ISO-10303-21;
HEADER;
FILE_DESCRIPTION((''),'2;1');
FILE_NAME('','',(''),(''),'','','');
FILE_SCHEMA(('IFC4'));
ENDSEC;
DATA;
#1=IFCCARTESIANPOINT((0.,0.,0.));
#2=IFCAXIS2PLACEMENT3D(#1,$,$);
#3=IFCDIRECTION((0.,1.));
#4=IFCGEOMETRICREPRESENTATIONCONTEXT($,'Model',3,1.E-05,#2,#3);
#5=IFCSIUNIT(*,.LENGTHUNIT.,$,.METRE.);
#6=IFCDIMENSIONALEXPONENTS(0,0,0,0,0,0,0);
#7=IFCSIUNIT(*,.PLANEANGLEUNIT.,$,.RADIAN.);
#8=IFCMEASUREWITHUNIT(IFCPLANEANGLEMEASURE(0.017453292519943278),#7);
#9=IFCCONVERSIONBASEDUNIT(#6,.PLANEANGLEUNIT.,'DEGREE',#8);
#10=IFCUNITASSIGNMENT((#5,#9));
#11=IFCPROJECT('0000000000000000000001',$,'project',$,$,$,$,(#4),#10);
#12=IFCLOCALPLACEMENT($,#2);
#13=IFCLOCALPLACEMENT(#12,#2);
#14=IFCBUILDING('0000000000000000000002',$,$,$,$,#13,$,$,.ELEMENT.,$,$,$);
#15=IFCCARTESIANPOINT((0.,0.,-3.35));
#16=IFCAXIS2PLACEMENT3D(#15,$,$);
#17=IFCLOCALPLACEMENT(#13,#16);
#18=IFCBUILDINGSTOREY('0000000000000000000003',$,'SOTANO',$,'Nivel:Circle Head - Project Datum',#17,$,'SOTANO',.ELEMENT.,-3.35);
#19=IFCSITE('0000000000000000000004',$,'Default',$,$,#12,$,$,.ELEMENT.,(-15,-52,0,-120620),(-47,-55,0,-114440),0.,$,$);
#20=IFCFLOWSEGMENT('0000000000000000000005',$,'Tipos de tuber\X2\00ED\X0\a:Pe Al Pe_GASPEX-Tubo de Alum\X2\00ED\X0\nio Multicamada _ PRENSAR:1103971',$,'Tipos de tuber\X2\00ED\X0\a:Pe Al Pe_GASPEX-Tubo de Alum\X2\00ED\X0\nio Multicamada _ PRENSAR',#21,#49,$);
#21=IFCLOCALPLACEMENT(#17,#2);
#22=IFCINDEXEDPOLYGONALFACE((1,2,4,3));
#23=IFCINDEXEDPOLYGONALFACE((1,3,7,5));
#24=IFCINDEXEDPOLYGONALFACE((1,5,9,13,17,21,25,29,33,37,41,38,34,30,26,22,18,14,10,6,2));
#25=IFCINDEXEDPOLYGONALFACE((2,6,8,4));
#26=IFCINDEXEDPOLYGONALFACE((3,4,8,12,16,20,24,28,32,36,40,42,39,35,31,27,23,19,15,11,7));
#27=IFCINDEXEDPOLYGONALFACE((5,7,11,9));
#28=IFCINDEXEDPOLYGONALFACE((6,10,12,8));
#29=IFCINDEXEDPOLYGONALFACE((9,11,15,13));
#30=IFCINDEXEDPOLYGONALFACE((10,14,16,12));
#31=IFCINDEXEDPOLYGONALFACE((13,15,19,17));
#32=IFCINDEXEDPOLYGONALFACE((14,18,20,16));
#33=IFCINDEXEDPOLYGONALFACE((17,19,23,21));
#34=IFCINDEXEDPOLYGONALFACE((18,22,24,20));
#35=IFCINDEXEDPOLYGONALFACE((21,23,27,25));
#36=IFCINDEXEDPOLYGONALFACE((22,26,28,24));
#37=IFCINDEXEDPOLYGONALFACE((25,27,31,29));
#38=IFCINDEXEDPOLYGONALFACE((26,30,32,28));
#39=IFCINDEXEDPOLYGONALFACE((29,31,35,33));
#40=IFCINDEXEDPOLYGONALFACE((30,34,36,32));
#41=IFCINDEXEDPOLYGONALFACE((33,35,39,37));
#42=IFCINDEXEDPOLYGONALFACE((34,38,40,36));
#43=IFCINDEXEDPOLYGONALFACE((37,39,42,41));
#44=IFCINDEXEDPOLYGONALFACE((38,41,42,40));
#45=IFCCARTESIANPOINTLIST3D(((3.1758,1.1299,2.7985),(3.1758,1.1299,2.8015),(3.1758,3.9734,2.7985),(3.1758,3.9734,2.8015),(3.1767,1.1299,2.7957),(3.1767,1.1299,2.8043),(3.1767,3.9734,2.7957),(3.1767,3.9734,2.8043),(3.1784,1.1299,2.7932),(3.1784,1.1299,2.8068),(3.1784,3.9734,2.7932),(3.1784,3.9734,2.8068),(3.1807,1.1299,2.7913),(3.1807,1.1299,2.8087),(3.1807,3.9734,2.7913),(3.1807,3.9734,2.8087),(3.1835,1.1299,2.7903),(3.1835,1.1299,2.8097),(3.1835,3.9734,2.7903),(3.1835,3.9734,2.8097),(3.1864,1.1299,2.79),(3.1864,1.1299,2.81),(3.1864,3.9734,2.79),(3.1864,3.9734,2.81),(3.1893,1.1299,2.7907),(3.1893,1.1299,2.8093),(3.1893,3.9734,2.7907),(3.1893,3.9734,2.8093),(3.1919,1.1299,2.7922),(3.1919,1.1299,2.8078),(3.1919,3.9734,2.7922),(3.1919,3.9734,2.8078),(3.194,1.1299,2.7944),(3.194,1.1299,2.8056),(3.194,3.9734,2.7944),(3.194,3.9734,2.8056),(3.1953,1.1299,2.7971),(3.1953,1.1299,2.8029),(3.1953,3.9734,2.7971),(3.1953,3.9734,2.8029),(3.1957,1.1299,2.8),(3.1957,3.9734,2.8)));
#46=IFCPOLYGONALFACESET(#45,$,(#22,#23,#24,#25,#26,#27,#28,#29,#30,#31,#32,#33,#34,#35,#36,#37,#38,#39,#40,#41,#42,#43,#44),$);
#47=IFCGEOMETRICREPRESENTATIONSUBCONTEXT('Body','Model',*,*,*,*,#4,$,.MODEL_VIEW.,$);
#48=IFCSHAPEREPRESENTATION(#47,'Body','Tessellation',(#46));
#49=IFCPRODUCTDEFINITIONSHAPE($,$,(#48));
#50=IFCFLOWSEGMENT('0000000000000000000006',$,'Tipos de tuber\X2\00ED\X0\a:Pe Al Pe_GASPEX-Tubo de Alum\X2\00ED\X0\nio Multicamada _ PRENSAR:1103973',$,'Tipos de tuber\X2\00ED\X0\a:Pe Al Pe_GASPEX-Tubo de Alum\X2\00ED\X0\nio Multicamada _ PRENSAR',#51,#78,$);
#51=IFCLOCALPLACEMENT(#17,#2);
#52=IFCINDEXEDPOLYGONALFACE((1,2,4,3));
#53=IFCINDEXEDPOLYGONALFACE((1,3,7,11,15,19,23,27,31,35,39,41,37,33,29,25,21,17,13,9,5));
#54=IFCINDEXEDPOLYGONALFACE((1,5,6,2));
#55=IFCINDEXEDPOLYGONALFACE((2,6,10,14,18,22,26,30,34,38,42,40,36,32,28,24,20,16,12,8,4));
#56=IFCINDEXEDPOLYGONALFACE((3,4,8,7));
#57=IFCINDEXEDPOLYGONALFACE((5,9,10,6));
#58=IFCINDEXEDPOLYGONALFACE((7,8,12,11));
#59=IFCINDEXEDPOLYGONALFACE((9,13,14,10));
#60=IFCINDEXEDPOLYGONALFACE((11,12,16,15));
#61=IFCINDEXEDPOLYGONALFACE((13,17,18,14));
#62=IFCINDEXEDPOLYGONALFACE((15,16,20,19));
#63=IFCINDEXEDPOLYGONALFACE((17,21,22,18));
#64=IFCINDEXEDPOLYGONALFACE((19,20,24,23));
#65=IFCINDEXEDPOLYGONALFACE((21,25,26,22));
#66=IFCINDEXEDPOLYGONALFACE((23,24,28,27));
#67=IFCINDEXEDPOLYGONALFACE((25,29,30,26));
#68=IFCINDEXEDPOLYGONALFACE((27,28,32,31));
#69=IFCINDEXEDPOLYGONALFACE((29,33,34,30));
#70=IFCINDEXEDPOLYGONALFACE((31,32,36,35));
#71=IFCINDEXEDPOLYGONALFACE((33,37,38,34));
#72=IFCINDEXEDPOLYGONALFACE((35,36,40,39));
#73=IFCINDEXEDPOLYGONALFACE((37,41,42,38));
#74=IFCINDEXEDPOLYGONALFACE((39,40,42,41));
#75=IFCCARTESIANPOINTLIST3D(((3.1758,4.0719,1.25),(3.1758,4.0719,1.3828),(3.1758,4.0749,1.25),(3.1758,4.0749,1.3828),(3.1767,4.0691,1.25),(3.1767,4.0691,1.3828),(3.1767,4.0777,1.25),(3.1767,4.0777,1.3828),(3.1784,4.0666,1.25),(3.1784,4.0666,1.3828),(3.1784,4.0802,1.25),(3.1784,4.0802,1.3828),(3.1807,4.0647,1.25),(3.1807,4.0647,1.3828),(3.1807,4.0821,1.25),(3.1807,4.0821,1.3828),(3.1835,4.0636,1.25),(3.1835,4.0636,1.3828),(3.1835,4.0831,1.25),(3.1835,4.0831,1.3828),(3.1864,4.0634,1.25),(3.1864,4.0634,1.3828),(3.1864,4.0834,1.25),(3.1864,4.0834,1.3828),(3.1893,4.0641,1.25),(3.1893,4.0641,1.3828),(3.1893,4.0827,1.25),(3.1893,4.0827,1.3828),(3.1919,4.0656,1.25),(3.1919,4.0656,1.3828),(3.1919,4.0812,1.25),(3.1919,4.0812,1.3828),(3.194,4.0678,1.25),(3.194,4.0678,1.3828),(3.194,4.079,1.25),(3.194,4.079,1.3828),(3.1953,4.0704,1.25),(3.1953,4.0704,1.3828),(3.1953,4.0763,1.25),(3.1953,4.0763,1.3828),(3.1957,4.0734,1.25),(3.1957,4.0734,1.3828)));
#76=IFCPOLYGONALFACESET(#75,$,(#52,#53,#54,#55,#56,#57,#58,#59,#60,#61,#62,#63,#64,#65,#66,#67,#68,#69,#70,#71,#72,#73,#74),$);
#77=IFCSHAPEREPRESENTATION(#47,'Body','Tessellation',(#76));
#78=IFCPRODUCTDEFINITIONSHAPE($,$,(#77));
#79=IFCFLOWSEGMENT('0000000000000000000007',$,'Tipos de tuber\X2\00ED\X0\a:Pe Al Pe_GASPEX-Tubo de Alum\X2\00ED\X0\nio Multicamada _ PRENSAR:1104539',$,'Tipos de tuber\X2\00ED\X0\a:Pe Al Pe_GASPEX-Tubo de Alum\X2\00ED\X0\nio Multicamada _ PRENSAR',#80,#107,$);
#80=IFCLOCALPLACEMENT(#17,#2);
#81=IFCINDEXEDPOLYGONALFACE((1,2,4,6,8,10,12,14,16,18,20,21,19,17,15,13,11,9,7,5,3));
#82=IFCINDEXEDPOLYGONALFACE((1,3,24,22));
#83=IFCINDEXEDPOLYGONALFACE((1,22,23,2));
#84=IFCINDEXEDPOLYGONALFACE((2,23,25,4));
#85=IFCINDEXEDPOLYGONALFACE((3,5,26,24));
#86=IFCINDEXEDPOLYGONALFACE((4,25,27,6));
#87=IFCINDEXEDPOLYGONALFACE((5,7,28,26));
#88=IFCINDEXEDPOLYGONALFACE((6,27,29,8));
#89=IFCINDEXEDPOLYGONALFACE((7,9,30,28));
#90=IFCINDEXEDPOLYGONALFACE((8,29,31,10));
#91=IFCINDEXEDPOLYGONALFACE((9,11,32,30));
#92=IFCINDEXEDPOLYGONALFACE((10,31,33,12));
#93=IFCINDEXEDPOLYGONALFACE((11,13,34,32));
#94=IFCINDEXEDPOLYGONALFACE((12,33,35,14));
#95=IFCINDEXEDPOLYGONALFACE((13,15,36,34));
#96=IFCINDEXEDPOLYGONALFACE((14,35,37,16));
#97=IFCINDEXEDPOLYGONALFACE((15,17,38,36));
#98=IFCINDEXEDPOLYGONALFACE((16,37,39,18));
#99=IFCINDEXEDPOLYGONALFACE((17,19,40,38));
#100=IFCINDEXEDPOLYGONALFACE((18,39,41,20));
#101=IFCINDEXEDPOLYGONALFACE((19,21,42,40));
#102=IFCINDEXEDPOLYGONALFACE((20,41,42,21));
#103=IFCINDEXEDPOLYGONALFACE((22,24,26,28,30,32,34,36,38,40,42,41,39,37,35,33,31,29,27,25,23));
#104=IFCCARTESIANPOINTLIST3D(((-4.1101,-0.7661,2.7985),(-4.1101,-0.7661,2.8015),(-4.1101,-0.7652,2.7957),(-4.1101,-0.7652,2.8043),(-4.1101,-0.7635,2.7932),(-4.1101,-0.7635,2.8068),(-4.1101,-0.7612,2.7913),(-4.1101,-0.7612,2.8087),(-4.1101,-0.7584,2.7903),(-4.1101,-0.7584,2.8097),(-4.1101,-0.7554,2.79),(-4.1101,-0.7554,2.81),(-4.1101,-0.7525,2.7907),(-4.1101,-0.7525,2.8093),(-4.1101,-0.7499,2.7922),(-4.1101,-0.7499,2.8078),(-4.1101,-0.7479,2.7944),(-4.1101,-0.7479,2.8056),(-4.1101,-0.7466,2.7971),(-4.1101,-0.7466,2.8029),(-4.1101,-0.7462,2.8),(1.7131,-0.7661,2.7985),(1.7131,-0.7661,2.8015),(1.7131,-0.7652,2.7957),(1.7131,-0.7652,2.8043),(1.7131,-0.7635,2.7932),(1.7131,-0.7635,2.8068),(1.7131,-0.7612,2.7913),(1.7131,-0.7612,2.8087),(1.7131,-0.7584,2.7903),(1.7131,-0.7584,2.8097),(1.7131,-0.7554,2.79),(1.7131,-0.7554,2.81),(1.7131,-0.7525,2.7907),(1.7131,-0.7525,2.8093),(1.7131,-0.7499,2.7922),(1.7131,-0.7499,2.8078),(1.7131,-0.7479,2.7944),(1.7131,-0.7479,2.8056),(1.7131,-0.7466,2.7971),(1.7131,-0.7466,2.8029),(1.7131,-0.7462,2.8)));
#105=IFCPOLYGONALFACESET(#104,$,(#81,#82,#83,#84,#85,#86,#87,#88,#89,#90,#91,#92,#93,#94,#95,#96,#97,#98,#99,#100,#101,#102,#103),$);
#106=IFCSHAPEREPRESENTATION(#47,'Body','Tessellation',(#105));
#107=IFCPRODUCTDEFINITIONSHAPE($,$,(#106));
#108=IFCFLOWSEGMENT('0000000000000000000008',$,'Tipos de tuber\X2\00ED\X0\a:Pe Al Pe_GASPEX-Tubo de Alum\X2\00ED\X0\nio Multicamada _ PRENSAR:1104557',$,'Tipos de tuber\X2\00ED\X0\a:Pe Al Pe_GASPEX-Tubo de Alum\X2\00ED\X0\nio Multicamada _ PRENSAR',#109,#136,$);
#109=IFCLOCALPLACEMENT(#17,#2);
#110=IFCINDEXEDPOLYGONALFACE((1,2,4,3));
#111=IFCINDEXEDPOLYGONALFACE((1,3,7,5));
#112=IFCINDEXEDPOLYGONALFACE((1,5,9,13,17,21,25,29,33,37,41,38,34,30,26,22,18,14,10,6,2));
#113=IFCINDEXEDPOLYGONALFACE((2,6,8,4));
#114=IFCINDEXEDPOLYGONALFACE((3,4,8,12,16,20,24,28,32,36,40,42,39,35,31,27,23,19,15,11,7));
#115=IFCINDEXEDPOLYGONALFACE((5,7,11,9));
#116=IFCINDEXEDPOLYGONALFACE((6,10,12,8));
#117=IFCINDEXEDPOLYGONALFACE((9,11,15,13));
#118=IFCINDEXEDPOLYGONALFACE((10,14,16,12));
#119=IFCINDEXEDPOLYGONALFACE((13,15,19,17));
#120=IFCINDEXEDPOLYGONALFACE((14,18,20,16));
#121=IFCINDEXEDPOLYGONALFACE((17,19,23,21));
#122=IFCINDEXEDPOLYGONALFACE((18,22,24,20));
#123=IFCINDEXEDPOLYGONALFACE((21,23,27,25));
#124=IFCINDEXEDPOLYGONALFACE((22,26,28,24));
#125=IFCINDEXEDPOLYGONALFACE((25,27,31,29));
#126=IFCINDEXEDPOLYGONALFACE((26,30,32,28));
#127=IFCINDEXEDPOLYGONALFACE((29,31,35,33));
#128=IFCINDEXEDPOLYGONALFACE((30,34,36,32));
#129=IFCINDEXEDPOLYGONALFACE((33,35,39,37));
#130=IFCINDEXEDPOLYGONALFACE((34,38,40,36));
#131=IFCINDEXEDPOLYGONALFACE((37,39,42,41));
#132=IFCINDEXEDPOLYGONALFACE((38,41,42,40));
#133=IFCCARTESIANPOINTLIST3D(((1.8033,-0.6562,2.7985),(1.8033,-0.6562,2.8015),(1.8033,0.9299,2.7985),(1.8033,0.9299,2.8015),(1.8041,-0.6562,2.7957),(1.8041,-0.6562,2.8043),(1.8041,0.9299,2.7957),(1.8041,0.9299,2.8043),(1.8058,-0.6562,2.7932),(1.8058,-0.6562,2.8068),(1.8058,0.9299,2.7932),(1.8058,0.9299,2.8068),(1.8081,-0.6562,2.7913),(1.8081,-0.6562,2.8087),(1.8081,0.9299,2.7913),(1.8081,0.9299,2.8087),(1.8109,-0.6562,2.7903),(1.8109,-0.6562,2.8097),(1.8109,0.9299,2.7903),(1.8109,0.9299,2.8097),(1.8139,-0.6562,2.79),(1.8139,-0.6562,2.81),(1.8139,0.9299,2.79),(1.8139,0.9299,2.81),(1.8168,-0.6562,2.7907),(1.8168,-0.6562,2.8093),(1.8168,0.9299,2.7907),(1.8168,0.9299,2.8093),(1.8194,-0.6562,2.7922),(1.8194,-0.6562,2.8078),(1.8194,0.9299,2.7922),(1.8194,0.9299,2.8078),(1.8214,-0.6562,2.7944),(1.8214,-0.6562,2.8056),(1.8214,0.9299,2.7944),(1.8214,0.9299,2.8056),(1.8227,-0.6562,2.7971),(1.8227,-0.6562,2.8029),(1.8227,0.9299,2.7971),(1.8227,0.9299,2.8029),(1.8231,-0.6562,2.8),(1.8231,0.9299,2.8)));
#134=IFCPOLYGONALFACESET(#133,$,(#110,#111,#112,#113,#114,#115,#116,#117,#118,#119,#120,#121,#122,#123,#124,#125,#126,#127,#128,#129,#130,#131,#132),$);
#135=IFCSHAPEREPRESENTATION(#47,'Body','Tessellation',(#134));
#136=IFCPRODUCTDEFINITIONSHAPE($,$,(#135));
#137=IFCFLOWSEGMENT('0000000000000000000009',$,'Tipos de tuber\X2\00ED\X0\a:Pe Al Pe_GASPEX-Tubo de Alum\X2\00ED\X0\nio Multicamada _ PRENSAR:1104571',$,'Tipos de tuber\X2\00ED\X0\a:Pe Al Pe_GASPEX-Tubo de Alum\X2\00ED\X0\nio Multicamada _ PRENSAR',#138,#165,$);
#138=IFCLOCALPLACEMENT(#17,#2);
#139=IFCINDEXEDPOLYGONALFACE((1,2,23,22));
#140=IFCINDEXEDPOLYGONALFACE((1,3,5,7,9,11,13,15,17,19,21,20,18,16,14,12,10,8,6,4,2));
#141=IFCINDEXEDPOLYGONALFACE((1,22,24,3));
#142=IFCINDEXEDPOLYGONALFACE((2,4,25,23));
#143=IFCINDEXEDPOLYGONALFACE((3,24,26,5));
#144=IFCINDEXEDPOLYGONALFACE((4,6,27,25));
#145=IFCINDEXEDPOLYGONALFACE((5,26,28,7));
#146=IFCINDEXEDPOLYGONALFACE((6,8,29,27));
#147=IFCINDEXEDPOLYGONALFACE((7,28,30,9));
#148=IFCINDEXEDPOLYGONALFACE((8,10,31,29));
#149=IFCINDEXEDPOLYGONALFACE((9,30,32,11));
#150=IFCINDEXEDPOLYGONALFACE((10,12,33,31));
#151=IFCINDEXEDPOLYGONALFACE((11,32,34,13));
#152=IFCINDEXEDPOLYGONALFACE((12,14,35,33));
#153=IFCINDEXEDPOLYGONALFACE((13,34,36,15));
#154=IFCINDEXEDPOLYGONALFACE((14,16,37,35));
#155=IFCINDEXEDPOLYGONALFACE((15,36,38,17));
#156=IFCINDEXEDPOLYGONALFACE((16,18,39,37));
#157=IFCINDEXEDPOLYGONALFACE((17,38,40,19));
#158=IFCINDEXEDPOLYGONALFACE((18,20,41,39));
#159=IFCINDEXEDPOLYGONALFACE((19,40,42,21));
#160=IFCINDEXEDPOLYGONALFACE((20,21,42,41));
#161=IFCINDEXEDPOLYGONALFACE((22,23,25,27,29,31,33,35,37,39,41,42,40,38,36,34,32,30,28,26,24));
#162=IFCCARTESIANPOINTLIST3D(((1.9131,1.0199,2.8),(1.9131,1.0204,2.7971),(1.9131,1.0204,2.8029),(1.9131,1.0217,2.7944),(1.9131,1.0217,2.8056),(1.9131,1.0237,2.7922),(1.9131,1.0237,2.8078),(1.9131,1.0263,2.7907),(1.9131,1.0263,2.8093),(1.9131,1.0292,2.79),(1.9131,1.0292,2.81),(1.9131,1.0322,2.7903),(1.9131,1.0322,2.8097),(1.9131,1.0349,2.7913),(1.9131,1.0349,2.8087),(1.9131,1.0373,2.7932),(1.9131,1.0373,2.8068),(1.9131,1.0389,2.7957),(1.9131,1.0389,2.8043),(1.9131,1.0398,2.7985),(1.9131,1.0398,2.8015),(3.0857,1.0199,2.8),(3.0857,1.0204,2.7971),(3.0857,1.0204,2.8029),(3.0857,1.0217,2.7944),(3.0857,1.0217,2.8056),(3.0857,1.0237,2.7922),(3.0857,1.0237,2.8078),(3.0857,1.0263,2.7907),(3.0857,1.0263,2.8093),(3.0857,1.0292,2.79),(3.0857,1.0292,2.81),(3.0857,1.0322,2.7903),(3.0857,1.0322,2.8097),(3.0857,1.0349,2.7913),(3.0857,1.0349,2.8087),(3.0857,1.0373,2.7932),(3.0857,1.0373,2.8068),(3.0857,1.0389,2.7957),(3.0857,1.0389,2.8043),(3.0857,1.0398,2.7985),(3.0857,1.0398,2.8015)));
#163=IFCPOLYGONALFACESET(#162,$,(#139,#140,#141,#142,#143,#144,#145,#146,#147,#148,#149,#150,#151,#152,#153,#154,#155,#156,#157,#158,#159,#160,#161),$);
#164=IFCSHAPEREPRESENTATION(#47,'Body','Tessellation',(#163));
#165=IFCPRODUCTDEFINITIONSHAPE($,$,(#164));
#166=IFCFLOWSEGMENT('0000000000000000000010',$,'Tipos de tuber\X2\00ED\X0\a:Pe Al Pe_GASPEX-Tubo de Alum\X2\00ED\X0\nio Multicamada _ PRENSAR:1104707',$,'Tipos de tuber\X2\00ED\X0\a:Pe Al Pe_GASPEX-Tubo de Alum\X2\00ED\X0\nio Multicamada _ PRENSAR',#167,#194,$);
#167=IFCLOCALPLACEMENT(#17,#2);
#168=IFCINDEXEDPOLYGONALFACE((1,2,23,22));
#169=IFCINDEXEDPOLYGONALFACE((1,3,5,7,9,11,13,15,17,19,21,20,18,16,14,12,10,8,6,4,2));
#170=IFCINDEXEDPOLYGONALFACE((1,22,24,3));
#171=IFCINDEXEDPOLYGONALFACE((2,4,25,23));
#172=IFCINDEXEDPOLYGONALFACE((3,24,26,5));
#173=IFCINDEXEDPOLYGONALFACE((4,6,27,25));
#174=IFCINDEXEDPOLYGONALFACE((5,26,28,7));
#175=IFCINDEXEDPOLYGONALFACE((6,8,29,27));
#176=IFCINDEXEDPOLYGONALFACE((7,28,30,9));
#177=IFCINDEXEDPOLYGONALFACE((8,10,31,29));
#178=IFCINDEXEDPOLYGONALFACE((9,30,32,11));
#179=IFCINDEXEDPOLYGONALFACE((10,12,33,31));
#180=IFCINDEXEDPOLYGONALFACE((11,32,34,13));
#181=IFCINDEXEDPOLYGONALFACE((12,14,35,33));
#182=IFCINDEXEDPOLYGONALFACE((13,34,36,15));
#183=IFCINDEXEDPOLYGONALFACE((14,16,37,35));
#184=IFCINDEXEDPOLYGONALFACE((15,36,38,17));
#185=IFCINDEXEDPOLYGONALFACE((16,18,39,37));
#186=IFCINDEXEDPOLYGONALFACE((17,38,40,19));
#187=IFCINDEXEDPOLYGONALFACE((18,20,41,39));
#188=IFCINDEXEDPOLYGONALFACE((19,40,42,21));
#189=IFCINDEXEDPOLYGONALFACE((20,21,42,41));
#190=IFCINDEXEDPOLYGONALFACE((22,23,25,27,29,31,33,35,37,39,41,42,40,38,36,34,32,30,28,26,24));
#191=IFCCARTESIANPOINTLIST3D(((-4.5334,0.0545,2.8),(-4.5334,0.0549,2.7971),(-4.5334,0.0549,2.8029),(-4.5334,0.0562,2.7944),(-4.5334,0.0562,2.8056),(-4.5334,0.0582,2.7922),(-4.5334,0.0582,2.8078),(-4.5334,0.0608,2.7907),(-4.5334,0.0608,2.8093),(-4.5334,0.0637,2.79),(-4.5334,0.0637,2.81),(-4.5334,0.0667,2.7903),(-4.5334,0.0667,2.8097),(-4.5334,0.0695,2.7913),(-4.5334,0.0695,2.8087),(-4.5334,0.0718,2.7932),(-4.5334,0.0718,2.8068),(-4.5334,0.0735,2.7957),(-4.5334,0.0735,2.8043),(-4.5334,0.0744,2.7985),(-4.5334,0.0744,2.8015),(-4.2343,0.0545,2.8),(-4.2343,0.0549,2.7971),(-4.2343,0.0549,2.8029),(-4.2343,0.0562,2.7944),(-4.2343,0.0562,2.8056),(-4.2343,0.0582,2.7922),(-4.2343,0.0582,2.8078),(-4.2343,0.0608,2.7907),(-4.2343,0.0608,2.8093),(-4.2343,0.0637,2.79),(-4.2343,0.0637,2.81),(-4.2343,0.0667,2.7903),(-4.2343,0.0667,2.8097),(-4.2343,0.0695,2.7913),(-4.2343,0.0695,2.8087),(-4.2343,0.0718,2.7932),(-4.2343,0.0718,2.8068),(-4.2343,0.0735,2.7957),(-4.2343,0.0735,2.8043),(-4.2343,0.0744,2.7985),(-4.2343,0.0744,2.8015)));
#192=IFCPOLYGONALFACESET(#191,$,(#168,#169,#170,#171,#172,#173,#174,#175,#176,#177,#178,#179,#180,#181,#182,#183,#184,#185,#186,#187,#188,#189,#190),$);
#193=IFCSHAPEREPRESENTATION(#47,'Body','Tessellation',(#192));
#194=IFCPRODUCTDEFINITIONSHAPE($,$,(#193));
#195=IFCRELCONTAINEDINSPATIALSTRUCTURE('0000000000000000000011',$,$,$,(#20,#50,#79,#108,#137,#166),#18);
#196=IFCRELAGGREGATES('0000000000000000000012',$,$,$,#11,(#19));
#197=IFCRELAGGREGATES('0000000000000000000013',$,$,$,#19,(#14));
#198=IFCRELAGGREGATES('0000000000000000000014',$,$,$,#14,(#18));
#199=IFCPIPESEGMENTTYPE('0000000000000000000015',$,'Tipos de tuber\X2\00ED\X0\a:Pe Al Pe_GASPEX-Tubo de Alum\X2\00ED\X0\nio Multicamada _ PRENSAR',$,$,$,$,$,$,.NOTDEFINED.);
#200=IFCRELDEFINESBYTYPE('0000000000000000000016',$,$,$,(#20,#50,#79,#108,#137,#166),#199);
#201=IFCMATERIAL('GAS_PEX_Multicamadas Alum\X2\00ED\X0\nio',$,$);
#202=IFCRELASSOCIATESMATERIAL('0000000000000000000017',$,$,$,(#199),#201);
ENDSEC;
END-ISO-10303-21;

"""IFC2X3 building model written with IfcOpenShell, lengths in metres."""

from ifc_helpers import new_model, entity, si_unit, converted_unit, direction, frame, frame_2d, origin, origin_2d_with_axis, place, context, subcontext, project, spatial, circle, extrude, material, type_object, element, save


model = new_model("IFC2X3")

# Units and contexts
model_context = context("Model", 3, precision=1e-05, world=origin(), true_north=direction((0.0, 1.0)))
body_context = subcontext(model_context, "Body", "Model", "MODEL_VIEW")
ifc_project = project(units=[si_unit("LENGTHUNIT", "METRE"), converted_unit("PLANEANGLEUNIT", "DEGREE", entity("IfcPlaneAngleMeasure", 0.017453292519943278), si_unit("PLANEANGLEUNIT", "RADIAN"), dimensions=[0, 0, 0, 0, 0, 0, 0])], contexts=[model_context])

# Site, building, storey
site_placement = place(None, origin())
site = spatial("IfcSite", under=ifc_project, at=site_placement, Name="Default", CompositionType="ELEMENT", RefLatitude=(-15, -52, 0, -120620), RefLongitude=(-47, -55, 0, -114440), RefElevation=0.0)
building_placement = place(site_placement, origin())
building = spatial("IfcBuilding", under=site, at=building_placement, CompositionType="ELEMENT")
storey_placement = place(building_placement, frame((0.0, 0.0, -3.35)))
storey = spatial("IfcBuildingStorey", under=building, at=storey_placement, Name="SOTANO", ObjectType="Nivel:Circle Head - Project Datum", LongName="SOTANO", CompositionType="ELEMENT", Elevation=-3.35)

# Flow segments
ifc_material = material(Name="GAS_PEX_Multicamadas Alumínio")
pipe_segment_type_1 = type_object("IfcPipeSegmentType", Name="Tipos de tubería:Pe Al Pe_GASPEX-Tubo de Alumínio Multicamada _ PRENSAR", PredefinedType="NOTDEFINED", material=ifc_material)
flow_segment_1_placement = place(storey_placement, origin())
element("IfcFlowSegment", 1, at=flow_segment_1_placement, inside=storey, type_object=pipe_segment_type_1, Name="Tipos de tubería:Pe Al Pe_GASPEX-Tubo de Alumínio Multicamada _ PRENSAR:1103971", ObjectType="Tipos de tubería:Pe Al Pe_GASPEX-Tubo de Alumínio Multicamada _ PRENSAR", context=body_context, shape_type="SweptSolid", body=[
    extrude(circle(Radius=0.01, at=origin_2d_with_axis()), frame((3.1857, 1.1299, 2.8), z_axis=(0.0, 1.0, 0.0), x_axis=(1.0, 0.0, 0.0)), (0.0, 0.0, 1.0), 2.8435),
])
flow_segment_2_placement = place(storey_placement, origin())
element("IfcFlowSegment", 2, at=flow_segment_2_placement, inside=storey, type_object=pipe_segment_type_1, Name="Tipos de tubería:Pe Al Pe_GASPEX-Tubo de Alumínio Multicamada _ PRENSAR:1103973", ObjectType="Tipos de tubería:Pe Al Pe_GASPEX-Tubo de Alumínio Multicamada _ PRENSAR", context=body_context, shape_type="SweptSolid", body=[
    extrude(circle(Radius=0.01, at=origin_2d_with_axis()), frame((3.1857, 4.0734, 1.25)), (0.0, 0.0, 1.0), 0.1328),
])
flow_segment_3_placement = place(storey_placement, origin())
element("IfcFlowSegment", 3, at=flow_segment_3_placement, inside=storey, type_object=pipe_segment_type_1, Name="Tipos de tubería:Pe Al Pe_GASPEX-Tubo de Alumínio Multicamada _ PRENSAR:1104539", ObjectType="Tipos de tubería:Pe Al Pe_GASPEX-Tubo de Alumínio Multicamada _ PRENSAR", context=body_context, shape_type="SweptSolid", body=[
    extrude(circle(Radius=0.01, at=frame_2d((0.0, 0.0), x_axis=(1.0, 0.0))), frame((-4.1101, -0.7562, 2.8), z_axis=(1.0, 0.0, 0.0), x_axis=(0.0, 1.0, 0.0)), (0.0, 0.0, 1.0), 5.8232),
])
flow_segment_4_placement = place(storey_placement, origin())
element("IfcFlowSegment", 4, at=flow_segment_4_placement, inside=storey, type_object=pipe_segment_type_1, Name="Tipos de tubería:Pe Al Pe_GASPEX-Tubo de Alumínio Multicamada _ PRENSAR:1104557", ObjectType="Tipos de tubería:Pe Al Pe_GASPEX-Tubo de Alumínio Multicamada _ PRENSAR", context=body_context, shape_type="SweptSolid", body=[
    extrude(circle(Radius=0.01, at=origin_2d_with_axis()), frame((1.8131, -0.6562, 2.8), z_axis=(0.0, 1.0, 0.0), x_axis=(1.0, 0.0, 0.0)), (0.0, 0.0, 1.0), 1.5861),
])
flow_segment_5_placement = place(storey_placement, origin())
element("IfcFlowSegment", 5, at=flow_segment_5_placement, inside=storey, type_object=pipe_segment_type_1, Name="Tipos de tubería:Pe Al Pe_GASPEX-Tubo de Alumínio Multicamada _ PRENSAR:1104571", ObjectType="Tipos de tubería:Pe Al Pe_GASPEX-Tubo de Alumínio Multicamada _ PRENSAR", context=body_context, shape_type="SweptSolid", body=[
    extrude(circle(Radius=0.01, at=origin_2d_with_axis()), frame((1.9131, 1.0299, 2.8), z_axis=(1.0, 0.0, 0.0), x_axis=(0.0, -1.0, 0.0)), (0.0, 0.0, 1.0), 1.1726),
])
flow_segment_6_placement = place(storey_placement, origin())
element("IfcFlowSegment", 6, at=flow_segment_6_placement, inside=storey, type_object=pipe_segment_type_1, Name="Tipos de tubería:Pe Al Pe_GASPEX-Tubo de Alumínio Multicamada _ PRENSAR:1104707", ObjectType="Tipos de tubería:Pe Al Pe_GASPEX-Tubo de Alumínio Multicamada _ PRENSAR", context=body_context, shape_type="SweptSolid", body=[
    extrude(circle(Radius=0.01, at=frame_2d((0.0, 0.0), x_axis=(1.0, 0.0))), frame((-4.5334, 0.0645, 2.8), z_axis=(1.0, 0.0, 0.0), x_axis=(0.0, -1.0, 0.0)), (0.0, 0.0, 1.0), 0.2991),
])

save(model, "model.ifc")
